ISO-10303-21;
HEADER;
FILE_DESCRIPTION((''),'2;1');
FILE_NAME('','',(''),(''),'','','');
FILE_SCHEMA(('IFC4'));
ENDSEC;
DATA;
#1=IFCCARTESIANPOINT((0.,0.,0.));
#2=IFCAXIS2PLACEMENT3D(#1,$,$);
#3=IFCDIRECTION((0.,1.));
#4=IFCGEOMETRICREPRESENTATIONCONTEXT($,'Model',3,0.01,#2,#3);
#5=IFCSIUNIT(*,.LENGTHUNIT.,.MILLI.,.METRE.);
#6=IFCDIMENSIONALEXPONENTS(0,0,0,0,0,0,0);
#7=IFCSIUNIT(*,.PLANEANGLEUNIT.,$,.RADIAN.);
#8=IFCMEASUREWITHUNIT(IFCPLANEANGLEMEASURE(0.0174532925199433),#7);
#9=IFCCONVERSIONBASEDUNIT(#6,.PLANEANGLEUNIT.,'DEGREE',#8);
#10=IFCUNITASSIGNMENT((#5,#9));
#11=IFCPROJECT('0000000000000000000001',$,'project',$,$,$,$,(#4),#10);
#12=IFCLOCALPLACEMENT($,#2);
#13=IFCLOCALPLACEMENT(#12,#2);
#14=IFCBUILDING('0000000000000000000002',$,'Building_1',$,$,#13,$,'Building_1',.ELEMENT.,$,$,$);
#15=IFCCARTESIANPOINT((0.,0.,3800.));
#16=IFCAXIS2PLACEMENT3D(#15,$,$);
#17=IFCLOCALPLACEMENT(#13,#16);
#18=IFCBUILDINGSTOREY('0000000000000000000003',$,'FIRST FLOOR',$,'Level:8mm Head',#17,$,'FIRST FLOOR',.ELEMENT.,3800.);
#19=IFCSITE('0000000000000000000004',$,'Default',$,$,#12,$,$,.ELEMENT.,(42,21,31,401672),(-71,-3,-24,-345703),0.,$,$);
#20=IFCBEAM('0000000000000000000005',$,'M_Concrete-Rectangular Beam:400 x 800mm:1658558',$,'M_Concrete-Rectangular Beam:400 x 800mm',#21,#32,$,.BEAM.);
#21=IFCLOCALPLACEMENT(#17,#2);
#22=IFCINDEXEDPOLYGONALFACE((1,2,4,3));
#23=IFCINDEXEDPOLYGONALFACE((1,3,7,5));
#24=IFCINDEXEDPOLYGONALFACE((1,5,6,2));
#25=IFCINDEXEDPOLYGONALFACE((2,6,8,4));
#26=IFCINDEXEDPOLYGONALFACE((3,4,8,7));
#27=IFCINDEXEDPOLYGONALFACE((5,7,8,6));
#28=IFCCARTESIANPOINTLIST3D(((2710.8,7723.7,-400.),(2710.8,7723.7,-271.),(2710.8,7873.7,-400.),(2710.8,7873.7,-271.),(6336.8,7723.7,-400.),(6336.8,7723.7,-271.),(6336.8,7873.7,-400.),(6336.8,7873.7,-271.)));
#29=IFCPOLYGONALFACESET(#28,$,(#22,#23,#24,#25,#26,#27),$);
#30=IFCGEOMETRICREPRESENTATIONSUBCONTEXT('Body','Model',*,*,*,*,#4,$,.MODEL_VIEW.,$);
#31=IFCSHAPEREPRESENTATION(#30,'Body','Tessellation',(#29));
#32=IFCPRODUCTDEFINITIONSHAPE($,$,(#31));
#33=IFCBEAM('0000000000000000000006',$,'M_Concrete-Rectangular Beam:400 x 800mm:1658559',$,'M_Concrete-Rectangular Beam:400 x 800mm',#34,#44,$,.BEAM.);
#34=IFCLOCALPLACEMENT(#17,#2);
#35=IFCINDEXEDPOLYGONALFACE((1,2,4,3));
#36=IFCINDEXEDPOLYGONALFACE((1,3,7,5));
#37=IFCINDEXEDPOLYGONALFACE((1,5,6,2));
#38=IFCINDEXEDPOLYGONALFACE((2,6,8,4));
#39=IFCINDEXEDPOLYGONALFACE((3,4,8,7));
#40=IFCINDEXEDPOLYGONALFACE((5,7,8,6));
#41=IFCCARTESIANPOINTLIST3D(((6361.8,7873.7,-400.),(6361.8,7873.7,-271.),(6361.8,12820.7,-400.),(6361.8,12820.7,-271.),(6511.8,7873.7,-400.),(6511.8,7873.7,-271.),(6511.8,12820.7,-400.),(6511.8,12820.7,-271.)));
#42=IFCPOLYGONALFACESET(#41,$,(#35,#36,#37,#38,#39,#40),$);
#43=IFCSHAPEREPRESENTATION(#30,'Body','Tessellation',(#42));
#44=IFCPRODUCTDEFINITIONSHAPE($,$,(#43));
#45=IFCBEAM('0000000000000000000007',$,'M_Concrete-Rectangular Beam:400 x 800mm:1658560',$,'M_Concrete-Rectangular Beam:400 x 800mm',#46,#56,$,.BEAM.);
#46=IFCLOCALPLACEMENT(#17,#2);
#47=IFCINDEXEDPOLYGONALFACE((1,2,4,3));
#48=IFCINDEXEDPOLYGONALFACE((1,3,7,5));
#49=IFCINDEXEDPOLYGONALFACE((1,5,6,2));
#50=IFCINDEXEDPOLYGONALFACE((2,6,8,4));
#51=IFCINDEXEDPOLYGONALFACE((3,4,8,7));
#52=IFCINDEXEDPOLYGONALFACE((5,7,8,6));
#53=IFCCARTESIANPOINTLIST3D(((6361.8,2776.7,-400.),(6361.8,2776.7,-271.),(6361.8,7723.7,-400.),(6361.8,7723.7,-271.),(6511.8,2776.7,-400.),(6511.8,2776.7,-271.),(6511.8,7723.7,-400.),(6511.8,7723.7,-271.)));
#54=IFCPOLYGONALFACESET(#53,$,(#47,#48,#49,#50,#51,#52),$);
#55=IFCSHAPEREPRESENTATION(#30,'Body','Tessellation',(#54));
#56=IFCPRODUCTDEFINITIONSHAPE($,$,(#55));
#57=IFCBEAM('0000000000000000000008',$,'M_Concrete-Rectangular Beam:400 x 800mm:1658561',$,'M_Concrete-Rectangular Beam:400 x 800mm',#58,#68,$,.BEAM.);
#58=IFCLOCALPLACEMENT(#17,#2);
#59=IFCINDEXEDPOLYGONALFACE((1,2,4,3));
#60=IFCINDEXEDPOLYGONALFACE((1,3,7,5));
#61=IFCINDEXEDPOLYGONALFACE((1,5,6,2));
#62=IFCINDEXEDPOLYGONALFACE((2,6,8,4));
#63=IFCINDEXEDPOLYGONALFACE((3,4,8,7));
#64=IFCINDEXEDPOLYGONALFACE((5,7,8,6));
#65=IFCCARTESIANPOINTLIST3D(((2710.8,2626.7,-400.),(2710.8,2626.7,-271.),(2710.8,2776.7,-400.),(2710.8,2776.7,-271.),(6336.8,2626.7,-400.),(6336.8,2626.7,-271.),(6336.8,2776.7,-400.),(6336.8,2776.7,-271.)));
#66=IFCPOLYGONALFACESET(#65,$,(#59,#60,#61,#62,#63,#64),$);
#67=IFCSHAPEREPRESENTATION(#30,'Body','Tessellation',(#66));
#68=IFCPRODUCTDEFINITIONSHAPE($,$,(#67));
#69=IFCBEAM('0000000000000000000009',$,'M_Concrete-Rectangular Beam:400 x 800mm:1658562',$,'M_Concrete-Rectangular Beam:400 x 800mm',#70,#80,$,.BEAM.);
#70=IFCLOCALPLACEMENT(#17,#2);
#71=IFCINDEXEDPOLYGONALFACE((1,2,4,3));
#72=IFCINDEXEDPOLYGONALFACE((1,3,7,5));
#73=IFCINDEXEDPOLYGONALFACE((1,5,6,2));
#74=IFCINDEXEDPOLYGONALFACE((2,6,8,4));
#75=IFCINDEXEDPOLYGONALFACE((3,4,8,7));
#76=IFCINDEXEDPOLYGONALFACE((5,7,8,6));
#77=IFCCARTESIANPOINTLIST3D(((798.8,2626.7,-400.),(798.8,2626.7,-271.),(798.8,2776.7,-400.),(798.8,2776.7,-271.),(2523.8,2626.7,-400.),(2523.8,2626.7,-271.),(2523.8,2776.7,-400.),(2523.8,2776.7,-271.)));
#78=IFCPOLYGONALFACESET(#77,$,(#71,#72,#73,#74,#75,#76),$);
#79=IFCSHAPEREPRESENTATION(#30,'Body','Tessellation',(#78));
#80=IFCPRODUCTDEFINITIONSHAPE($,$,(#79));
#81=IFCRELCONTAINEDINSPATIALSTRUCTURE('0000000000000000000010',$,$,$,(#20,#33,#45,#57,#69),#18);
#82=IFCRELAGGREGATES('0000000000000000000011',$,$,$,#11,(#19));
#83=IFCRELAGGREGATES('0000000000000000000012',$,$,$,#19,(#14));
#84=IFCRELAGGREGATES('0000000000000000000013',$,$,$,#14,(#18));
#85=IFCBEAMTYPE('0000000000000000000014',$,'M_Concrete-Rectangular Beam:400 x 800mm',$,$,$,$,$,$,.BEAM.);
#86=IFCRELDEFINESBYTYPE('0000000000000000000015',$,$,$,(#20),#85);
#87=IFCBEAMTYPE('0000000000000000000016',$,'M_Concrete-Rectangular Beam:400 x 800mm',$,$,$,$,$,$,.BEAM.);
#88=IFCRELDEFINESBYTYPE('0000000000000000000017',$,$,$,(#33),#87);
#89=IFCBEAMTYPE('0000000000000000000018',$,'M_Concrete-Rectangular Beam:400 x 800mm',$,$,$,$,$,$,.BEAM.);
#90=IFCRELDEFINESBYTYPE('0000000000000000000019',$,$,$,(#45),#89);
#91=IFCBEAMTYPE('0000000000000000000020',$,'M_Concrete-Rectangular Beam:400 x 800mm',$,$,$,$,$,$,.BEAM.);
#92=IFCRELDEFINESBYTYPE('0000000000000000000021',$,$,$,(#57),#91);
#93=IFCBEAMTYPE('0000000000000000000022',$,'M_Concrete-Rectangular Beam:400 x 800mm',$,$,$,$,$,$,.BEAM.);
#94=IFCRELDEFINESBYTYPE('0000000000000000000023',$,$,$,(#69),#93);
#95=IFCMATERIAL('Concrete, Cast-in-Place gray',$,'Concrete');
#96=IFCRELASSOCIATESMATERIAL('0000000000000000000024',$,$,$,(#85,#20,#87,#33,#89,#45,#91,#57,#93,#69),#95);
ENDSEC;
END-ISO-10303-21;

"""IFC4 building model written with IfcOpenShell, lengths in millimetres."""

from ifc_helpers import new_model, entity, si_unit, converted_unit, direction, frame, origin, place, context, subcontext, project, spatial, indexed_curve, outline, extrude, source, transform, mapped, material, type_object, type_shapes, element, save


model = new_model("IFC4")

# Units and contexts
model_context = context("Model", 3, precision=0.01, world=origin(), true_north=direction((0.0, 1.0)))
body_context = subcontext(model_context, "Body", "Model", "MODEL_VIEW")
ifc_project = project(units=[si_unit("LENGTHUNIT", "METRE", prefix="MILLI"), converted_unit("PLANEANGLEUNIT", "DEGREE", entity("IfcPlaneAngleMeasure", 0.0174532925199433), si_unit("PLANEANGLEUNIT", "RADIAN"), dimensions=[0, 0, 0, 0, 0, 0, 0])], contexts=[model_context])

# Site, building, storey
site_placement = place(None, origin())
site = spatial("IfcSite", under=ifc_project, at=site_placement, Name="Default", CompositionType="ELEMENT", RefLatitude=(42, 21, 31, 401672), RefLongitude=(-71, -3, -24, -345703), RefElevation=0.0)
building_placement = place(site_placement, origin())
building = spatial("IfcBuilding", under=site, at=building_placement, Name="Building_1", LongName="Building_1", CompositionType="ELEMENT")
storey_placement = place(building_placement, frame((0.0, 0.0, 3800.0)))
storey = spatial("IfcBuildingStorey", under=building, at=storey_placement, Name="FIRST FLOOR", ObjectType="Level:8mm Head", LongName="FIRST FLOOR", CompositionType="ELEMENT", Elevation=3800.0)

# Beams
ifc_material = material(Name="Concrete, Cast-in-Place gray", Category="Concrete")
beam_type_1 = type_object("IfcBeamType", Name="M_Concrete-Rectangular Beam:400 x 800mm", PredefinedType="BEAM", material=ifc_material)
shared_shape_1 = source(origin(), body_context, "Body", "SweptSolid", [
    extrude(outline(indexed_curve([(-64.5, -75.0), (64.5, -75.0), (64.5, 75.0), (-64.5, 75.0), (-64.5, -75.0)], self_intersect=False)), frame((2710.8, 7798.7, 3464.5), z_axis=(1.0, 0.0, 0.0), x_axis=(0.0, 0.0, -1.0)), (0.0, 0.0, 1.0), 3626.0),
])
type_shapes(beam_type_1, [shared_shape_1])
beam_1_placement = place(storey_placement, frame((0.0, 0.0, -3800.0)))
element("IfcBeam", 1, at=beam_1_placement, inside=storey, type_object=beam_type_1, material=ifc_material, Name="M_Concrete-Rectangular Beam:400 x 800mm:1658558", ObjectType="M_Concrete-Rectangular Beam:400 x 800mm", PredefinedType="BEAM", context=body_context, shape_type="MappedRepresentation", body=[
    mapped(shared_shape_1, transform((0.0, 0.0, 0.0), scale=1.0)),
])
beam_type_2 = type_object("IfcBeamType", Name="M_Concrete-Rectangular Beam:400 x 800mm", PredefinedType="BEAM", material=ifc_material)
shared_shape_2 = source(origin(), body_context, "Body", "SweptSolid", [
    extrude(outline(indexed_curve([(-75.0, -64.5), (75.0, -64.5), (75.0, 64.5), (-75.0, 64.5), (-75.0, -64.5)], self_intersect=False)), frame((6436.8, 12820.7, 3464.5), z_axis=(0.0, -1.0, 0.0), x_axis=(-1.0, 0.0, 0.0)), (0.0, 0.0, 1.0), 4947.0),
])
type_shapes(beam_type_2, [shared_shape_2])
beam_2_placement = place(storey_placement, frame((0.0, 0.0, -3800.0)))
element("IfcBeam", 2, at=beam_2_placement, inside=storey, type_object=beam_type_2, material=ifc_material, Name="M_Concrete-Rectangular Beam:400 x 800mm:1658559", ObjectType="M_Concrete-Rectangular Beam:400 x 800mm", PredefinedType="BEAM", context=body_context, shape_type="MappedRepresentation", body=[
    mapped(shared_shape_2, transform((0.0, 0.0, 0.0), scale=1.0)),
])
beam_type_3 = type_object("IfcBeamType", Name="M_Concrete-Rectangular Beam:400 x 800mm", PredefinedType="BEAM", material=ifc_material)
shared_shape_3 = source(origin(), body_context, "Body", "SweptSolid", [
    extrude(outline(indexed_curve([(-75.0, -64.5), (75.0, -64.5), (75.0, 64.5), (-75.0, 64.5), (-75.0, -64.5)], self_intersect=False)), frame((6436.8, 7723.7, 3464.5), z_axis=(0.0, -1.0, 0.0), x_axis=(-1.0, 0.0, 0.0)), (0.0, 0.0, 1.0), 4947.0),
])
type_shapes(beam_type_3, [shared_shape_3])
beam_3_placement = place(storey_placement, frame((0.0, 0.0, -3800.0)))
element("IfcBeam", 3, at=beam_3_placement, inside=storey, type_object=beam_type_3, material=ifc_material, Name="M_Concrete-Rectangular Beam:400 x 800mm:1658560", ObjectType="M_Concrete-Rectangular Beam:400 x 800mm", PredefinedType="BEAM", context=body_context, shape_type="MappedRepresentation", body=[
    mapped(shared_shape_3, transform((0.0, 0.0, 0.0), scale=1.0)),
])
beam_type_4 = type_object("IfcBeamType", Name="M_Concrete-Rectangular Beam:400 x 800mm", PredefinedType="BEAM", material=ifc_material)
shared_shape_4 = source(origin(), body_context, "Body", "SweptSolid", [
    extrude(outline(indexed_curve([(-64.5, -75.0), (64.5, -75.0), (64.5, 75.0), (-64.5, 75.0), (-64.5, -75.0)], self_intersect=False)), frame((6336.8, 2701.7, 3464.5), z_axis=(-1.0, 0.0, 0.0), x_axis=(0.0, 0.0, -1.0)), (0.0, 0.0, 1.0), 3626.0),
])
type_shapes(beam_type_4, [shared_shape_4])
beam_4_placement = place(storey_placement, frame((0.0, 0.0, -3800.0)))
element("IfcBeam", 4, at=beam_4_placement, inside=storey, type_object=beam_type_4, material=ifc_material, Name="M_Concrete-Rectangular Beam:400 x 800mm:1658561", ObjectType="M_Concrete-Rectangular Beam:400 x 800mm", PredefinedType="BEAM", context=body_context, shape_type="MappedRepresentation", body=[
    mapped(shared_shape_4, transform((0.0, 0.0, 0.0), scale=1.0)),
])
beam_type_5 = type_object("IfcBeamType", Name="M_Concrete-Rectangular Beam:400 x 800mm", PredefinedType="BEAM", material=ifc_material)
shared_shape_5 = source(origin(), body_context, "Body", "SweptSolid", [
    extrude(outline(indexed_curve([(-64.5, -75.0), (64.5, -75.0), (64.5, 75.0), (-64.5, 75.0), (-64.5, -75.0)], self_intersect=False)), frame((2523.8, 2701.7, 3464.5), z_axis=(-1.0, 0.0, 0.0), x_axis=(0.0, 0.0, -1.0)), (0.0, 0.0, 1.0), 1725.0),
])
type_shapes(beam_type_5, [shared_shape_5])
beam_5_placement = place(storey_placement, frame((0.0, 0.0, -3800.0)))
element("IfcBeam", 5, at=beam_5_placement, inside=storey, type_object=beam_type_5, material=ifc_material, Name="M_Concrete-Rectangular Beam:400 x 800mm:1658562", ObjectType="M_Concrete-Rectangular Beam:400 x 800mm", PredefinedType="BEAM", context=body_context, shape_type="MappedRepresentation", body=[
    mapped(shared_shape_5, transform((0.0, 0.0, 0.0), scale=1.0)),
])

save(model, "model.ifc")
